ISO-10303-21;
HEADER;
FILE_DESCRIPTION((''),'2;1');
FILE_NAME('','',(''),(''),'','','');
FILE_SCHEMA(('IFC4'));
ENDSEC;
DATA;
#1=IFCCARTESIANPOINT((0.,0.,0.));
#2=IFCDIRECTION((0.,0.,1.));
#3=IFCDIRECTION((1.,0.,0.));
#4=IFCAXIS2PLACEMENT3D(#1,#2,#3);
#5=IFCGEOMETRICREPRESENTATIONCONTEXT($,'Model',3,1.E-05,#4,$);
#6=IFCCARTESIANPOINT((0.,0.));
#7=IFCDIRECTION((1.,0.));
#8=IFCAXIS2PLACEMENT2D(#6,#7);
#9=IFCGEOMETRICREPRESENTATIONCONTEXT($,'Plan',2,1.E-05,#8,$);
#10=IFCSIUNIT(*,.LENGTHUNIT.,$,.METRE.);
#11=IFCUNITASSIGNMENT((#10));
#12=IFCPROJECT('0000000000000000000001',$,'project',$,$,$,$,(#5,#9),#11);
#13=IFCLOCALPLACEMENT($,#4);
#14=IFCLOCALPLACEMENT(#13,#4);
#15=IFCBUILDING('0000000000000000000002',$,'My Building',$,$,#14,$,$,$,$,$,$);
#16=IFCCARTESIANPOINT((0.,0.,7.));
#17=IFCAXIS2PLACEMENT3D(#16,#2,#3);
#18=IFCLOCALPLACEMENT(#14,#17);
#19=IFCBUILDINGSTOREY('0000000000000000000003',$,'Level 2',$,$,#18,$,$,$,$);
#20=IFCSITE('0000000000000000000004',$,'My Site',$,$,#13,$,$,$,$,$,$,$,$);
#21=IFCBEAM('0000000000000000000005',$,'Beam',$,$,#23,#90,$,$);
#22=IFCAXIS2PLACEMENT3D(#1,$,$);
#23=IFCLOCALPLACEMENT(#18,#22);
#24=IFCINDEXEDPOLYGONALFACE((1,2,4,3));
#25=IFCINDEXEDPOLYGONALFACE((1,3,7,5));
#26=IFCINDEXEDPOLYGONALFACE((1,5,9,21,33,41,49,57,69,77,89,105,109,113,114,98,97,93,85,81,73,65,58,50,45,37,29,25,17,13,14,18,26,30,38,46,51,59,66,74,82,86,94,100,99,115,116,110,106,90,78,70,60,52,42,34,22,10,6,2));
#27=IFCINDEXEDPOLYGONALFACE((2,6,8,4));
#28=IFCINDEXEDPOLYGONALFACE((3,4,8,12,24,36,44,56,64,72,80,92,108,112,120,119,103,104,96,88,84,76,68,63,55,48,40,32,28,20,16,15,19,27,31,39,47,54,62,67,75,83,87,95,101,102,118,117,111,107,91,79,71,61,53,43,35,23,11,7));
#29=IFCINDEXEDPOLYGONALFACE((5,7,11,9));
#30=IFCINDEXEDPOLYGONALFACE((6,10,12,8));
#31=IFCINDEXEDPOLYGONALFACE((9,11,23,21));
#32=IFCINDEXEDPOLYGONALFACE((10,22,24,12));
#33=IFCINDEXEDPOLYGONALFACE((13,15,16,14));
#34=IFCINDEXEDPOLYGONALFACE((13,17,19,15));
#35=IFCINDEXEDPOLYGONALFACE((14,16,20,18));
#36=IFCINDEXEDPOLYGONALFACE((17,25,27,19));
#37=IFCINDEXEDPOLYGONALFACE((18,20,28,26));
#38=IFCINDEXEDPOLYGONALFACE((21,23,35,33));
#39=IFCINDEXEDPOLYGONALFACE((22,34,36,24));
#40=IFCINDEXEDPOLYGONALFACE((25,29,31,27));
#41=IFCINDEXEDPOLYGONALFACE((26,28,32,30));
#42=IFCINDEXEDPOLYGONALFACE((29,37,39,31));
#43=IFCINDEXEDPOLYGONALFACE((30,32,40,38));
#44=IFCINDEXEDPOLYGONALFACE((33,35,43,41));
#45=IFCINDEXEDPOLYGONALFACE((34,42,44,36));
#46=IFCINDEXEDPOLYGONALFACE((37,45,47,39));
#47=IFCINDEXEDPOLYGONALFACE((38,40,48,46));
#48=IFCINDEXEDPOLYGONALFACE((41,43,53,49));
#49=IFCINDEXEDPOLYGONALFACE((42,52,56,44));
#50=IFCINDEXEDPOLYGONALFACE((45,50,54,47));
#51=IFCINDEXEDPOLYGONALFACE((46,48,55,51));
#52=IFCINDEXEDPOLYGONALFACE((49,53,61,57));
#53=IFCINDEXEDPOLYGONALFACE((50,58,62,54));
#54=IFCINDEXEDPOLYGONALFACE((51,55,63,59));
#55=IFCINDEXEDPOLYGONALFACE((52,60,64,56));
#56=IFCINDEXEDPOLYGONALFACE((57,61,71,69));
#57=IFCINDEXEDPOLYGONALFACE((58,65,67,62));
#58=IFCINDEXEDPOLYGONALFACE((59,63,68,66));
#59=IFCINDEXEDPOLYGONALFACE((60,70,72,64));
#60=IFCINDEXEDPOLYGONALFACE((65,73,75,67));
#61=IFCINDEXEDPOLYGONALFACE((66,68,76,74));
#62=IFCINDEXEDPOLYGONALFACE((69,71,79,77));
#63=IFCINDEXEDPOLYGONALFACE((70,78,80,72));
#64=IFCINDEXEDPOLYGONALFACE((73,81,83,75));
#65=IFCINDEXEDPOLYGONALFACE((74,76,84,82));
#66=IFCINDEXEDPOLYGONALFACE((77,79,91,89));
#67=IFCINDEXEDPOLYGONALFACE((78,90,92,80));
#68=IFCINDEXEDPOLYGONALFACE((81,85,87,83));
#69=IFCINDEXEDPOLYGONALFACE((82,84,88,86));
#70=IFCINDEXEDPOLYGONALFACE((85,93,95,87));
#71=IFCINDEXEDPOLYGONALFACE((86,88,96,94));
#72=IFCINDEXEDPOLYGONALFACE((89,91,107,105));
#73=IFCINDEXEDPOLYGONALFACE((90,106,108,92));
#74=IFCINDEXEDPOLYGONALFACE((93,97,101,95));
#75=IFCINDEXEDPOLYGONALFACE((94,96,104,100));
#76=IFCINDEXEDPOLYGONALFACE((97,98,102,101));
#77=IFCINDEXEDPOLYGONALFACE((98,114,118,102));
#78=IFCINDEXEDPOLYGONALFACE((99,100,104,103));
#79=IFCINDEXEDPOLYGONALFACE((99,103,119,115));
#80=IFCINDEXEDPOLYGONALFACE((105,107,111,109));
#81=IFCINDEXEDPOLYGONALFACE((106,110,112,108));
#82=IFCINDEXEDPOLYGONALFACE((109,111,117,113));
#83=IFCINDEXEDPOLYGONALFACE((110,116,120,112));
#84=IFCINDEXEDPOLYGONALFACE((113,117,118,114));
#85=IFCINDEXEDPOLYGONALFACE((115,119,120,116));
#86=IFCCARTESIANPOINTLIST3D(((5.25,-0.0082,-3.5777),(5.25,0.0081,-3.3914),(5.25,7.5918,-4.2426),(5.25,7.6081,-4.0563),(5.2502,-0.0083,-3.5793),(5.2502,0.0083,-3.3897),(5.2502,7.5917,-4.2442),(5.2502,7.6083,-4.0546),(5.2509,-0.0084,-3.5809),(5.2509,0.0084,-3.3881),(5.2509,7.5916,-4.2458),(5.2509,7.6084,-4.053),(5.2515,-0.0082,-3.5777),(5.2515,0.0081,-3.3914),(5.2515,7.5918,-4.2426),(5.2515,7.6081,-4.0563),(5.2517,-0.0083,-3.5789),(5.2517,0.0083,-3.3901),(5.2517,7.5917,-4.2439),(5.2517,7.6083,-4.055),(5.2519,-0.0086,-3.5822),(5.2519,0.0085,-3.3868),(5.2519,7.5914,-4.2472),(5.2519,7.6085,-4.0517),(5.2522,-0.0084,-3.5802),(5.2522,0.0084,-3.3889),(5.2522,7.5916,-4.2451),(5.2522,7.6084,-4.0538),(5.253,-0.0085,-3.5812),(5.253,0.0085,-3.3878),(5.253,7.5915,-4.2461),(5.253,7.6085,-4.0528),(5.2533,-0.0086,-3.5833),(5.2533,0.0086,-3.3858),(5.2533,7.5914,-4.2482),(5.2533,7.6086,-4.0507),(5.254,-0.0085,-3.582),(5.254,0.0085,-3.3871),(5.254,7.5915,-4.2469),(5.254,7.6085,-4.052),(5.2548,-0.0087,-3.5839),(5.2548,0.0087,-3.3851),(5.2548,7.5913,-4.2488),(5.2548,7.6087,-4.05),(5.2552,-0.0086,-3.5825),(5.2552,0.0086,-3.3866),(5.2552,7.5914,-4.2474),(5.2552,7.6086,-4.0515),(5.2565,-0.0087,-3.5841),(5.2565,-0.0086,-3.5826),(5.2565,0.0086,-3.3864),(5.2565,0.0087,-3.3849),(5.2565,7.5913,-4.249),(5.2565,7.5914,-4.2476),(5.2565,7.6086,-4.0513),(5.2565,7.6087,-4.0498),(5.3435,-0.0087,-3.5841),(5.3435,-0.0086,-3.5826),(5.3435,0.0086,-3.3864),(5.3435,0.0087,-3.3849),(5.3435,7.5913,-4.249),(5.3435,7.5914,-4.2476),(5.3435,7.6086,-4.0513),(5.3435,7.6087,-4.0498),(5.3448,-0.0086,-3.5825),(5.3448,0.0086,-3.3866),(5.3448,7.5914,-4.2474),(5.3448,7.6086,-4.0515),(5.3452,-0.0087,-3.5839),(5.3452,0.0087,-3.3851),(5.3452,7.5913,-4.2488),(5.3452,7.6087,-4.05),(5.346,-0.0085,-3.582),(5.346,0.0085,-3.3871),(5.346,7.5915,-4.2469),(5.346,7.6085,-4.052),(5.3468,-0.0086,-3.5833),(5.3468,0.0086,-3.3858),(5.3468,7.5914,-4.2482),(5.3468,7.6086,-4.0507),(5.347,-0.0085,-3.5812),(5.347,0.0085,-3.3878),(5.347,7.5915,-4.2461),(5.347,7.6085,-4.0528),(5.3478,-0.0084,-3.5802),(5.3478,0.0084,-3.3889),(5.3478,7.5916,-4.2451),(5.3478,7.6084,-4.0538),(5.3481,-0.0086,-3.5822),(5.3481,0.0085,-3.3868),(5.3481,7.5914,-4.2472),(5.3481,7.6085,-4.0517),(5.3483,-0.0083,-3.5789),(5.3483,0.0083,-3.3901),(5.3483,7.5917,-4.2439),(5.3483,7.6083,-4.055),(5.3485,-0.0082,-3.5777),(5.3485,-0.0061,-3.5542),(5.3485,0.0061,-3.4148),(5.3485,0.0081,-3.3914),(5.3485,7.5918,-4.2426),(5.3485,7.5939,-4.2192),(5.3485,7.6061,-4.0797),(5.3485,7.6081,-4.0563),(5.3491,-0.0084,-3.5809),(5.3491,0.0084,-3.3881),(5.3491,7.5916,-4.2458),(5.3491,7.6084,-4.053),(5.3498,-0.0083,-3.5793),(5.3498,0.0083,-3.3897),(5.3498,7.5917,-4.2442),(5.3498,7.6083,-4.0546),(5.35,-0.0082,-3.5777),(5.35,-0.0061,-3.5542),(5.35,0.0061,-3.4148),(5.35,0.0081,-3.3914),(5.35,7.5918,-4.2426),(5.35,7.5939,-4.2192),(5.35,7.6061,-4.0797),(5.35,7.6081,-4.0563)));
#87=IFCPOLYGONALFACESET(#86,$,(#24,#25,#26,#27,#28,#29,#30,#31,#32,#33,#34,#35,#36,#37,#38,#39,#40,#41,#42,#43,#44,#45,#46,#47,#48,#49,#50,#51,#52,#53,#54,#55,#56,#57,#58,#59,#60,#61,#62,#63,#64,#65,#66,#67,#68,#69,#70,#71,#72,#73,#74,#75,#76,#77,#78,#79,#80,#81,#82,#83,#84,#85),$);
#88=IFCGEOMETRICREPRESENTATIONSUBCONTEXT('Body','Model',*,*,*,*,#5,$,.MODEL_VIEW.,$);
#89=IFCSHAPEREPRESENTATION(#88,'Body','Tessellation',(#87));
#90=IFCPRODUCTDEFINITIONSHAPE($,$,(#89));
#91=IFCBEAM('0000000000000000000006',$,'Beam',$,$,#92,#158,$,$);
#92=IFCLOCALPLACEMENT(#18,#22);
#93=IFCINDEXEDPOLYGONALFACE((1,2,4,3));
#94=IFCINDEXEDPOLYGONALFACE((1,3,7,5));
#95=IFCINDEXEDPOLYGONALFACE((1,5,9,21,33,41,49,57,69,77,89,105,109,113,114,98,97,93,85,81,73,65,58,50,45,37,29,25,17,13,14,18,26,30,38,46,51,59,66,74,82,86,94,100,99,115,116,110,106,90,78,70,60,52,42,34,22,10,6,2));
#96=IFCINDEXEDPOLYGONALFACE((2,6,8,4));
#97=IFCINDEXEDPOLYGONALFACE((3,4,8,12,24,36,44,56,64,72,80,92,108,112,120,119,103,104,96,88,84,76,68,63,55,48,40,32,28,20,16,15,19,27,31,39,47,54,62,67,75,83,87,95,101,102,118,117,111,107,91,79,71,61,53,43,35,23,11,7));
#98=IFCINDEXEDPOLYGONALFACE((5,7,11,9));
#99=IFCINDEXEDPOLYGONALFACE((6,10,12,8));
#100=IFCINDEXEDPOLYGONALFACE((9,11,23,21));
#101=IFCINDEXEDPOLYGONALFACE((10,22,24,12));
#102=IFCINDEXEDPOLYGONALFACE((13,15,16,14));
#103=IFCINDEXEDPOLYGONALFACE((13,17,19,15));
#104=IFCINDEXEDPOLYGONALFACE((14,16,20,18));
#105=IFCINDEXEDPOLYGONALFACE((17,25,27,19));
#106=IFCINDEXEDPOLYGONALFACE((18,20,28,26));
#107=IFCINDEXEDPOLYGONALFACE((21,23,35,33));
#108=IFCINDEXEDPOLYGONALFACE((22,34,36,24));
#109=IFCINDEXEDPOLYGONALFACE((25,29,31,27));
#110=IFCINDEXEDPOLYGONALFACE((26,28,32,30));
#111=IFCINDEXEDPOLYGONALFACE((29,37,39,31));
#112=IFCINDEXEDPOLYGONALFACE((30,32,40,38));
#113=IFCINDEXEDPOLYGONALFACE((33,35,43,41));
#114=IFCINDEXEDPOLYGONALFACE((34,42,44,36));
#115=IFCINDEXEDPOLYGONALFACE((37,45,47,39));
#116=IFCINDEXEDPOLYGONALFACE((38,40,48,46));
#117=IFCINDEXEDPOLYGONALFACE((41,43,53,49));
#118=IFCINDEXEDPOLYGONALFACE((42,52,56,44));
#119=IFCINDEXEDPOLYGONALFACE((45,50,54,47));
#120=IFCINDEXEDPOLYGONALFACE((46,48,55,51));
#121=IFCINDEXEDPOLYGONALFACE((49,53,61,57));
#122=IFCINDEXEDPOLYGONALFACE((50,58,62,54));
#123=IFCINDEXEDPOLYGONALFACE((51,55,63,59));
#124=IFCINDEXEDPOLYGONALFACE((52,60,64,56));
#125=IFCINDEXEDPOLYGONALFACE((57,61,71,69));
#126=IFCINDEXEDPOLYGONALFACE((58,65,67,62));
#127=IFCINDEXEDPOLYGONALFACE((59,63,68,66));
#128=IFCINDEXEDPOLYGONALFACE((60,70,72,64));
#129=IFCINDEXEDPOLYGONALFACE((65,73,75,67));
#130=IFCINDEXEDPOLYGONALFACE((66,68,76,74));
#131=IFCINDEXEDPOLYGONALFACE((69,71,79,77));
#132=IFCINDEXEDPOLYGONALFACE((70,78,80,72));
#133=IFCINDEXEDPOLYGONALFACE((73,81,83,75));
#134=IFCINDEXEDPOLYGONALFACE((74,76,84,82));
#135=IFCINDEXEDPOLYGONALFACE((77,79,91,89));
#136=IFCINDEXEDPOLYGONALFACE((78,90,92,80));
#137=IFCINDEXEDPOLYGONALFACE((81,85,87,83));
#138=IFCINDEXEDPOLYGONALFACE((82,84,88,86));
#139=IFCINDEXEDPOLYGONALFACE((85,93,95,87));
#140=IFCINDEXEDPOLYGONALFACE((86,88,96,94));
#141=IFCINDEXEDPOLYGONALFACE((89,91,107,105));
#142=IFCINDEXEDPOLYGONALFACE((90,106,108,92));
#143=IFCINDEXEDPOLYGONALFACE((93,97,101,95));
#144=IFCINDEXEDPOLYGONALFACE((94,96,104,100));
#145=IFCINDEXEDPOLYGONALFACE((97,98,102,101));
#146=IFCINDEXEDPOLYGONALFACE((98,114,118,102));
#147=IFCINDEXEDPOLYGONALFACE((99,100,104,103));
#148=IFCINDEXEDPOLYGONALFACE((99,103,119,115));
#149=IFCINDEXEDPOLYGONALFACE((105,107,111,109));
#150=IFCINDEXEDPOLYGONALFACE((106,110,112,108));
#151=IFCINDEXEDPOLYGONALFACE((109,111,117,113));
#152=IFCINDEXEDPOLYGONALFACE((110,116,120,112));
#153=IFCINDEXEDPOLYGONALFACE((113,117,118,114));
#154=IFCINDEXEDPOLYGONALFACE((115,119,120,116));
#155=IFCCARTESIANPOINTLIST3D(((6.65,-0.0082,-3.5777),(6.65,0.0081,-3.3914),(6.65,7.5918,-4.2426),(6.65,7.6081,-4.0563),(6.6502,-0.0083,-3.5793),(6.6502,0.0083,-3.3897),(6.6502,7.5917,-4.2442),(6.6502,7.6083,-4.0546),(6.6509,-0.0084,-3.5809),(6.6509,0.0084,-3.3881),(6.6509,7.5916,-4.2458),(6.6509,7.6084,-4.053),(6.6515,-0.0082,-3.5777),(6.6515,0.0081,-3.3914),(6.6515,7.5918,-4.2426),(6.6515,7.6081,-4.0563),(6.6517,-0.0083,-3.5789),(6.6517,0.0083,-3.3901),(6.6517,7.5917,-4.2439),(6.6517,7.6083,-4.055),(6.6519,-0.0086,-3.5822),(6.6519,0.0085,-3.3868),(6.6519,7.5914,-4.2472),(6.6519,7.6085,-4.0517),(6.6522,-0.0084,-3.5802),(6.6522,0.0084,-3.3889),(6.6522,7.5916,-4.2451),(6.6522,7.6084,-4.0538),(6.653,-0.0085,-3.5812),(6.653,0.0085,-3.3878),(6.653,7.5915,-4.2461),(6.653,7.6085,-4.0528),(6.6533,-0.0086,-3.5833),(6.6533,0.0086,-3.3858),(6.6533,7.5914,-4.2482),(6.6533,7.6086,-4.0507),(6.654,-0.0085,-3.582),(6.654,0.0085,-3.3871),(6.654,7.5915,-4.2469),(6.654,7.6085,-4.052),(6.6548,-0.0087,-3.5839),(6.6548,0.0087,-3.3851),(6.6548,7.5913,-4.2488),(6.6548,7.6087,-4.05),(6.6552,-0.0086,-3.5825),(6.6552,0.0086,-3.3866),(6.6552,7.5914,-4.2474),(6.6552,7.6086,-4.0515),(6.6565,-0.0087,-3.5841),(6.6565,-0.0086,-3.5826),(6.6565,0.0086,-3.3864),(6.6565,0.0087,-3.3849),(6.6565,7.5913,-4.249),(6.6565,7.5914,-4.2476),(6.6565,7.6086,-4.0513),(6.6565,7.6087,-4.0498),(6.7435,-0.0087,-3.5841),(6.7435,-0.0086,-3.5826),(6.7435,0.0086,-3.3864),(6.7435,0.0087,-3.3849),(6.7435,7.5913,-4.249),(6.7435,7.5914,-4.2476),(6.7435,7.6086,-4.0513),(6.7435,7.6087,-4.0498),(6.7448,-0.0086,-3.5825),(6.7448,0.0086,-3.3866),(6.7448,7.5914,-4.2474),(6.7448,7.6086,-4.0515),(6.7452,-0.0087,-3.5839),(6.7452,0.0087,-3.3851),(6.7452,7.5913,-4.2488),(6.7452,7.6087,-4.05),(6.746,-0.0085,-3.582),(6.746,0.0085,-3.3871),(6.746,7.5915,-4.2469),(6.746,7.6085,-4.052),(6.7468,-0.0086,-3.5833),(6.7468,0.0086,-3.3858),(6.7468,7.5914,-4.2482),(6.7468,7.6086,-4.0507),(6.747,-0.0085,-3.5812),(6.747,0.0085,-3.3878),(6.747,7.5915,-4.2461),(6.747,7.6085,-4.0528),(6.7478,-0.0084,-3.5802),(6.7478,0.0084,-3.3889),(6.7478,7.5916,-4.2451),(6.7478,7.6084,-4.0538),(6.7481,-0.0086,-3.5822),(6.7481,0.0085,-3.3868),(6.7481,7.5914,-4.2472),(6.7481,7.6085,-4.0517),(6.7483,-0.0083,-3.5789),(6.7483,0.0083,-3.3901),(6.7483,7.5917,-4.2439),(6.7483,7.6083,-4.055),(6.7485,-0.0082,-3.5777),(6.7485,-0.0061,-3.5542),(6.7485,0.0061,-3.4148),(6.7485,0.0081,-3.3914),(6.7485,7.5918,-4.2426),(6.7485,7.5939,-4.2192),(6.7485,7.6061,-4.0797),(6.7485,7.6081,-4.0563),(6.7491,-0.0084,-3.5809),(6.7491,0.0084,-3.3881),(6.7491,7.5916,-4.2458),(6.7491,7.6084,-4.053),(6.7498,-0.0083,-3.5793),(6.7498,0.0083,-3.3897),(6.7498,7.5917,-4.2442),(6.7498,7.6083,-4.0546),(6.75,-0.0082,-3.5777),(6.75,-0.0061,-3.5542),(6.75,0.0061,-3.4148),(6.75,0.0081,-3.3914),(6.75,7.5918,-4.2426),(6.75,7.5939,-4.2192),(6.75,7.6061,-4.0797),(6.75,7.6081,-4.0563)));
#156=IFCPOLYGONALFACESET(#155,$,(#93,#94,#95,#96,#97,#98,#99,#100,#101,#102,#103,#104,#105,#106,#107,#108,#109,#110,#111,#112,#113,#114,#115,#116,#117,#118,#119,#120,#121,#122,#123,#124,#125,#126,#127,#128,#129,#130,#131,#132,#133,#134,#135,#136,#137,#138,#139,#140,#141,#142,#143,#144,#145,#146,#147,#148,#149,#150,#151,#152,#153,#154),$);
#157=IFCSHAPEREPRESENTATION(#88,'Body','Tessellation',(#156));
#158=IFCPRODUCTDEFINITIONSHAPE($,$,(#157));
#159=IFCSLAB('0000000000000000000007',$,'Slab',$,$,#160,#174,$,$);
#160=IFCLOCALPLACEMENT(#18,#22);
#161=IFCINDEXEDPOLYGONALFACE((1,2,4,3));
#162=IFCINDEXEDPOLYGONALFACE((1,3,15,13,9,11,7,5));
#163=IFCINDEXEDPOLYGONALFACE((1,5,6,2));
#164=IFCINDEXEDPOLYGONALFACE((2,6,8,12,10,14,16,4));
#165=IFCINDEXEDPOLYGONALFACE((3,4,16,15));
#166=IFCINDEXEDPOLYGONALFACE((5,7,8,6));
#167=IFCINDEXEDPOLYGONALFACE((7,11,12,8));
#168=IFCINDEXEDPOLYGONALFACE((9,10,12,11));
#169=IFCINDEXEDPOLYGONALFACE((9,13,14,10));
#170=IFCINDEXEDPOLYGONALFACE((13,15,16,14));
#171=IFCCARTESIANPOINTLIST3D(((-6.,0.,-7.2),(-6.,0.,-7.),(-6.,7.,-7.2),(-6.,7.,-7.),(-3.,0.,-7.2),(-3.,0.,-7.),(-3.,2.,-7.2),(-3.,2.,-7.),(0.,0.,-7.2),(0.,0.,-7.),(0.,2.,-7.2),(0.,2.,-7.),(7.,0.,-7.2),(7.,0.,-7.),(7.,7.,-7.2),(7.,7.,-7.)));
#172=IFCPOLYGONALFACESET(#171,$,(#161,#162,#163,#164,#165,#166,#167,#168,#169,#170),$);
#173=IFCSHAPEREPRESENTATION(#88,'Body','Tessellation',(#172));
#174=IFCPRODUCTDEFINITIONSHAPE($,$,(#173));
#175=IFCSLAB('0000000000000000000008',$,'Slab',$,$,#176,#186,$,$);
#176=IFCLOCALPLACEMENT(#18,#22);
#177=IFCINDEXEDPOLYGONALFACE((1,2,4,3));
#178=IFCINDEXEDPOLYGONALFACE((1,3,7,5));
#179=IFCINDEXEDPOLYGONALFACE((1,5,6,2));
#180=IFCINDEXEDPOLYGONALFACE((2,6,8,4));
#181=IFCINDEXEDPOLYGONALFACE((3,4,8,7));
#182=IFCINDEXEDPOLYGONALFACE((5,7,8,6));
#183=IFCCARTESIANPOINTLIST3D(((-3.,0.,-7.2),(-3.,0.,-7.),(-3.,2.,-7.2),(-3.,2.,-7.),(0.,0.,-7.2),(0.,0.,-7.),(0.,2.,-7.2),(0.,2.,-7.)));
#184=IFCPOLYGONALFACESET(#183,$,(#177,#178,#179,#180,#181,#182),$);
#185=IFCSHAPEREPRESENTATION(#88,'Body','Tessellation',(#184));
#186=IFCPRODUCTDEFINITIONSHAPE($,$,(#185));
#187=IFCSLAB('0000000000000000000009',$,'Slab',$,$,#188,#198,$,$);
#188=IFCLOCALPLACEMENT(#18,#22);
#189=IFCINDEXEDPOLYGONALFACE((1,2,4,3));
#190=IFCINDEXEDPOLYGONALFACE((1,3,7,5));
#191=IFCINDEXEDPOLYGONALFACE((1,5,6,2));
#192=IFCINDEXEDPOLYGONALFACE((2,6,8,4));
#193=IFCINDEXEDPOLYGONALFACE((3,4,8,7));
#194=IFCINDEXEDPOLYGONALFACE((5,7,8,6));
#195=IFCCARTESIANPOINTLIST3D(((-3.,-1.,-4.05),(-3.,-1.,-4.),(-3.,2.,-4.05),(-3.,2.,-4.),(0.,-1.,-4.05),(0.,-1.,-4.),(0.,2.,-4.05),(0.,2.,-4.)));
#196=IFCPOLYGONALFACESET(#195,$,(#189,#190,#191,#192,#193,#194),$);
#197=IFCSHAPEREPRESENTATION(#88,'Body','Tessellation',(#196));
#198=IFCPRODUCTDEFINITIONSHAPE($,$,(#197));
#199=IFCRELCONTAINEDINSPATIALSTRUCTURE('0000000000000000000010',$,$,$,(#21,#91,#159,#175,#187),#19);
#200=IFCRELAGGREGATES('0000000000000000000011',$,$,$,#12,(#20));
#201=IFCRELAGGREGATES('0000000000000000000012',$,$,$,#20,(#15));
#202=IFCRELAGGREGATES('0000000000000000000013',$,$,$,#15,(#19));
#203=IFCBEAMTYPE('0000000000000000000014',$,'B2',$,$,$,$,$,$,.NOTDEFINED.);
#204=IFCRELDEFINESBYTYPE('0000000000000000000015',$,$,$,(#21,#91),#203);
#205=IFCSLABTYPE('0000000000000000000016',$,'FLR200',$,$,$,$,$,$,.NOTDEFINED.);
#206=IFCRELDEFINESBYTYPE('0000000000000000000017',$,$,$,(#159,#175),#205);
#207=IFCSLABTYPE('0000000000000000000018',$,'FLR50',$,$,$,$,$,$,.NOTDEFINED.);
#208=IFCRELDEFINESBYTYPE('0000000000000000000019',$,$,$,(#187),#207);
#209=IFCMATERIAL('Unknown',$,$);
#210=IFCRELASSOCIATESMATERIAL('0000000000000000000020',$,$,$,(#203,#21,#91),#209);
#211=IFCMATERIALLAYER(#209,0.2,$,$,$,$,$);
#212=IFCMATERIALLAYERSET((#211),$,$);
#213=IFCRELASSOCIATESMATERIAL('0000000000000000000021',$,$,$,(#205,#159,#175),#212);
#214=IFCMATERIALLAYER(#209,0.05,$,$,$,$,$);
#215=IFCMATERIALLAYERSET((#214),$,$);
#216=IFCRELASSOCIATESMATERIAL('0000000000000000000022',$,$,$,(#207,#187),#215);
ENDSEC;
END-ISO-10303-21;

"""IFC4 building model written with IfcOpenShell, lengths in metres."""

from ifc_helpers import new_model, si_unit, frame, origin_with_axes, origin_2d_with_axis, place, context, subcontext, project, spatial, indexed_curve, c_section, outline, extrude, material, layer, layer_set, layer_usage, material_profile, profile_set, profile_usage, type_object, element, save


model = new_model("IFC4")

# Units and contexts
model_context = context("Model", 3, precision=1e-05, world=origin_with_axes())
plan_context = context("Plan", 2, precision=1e-05, world=origin_2d_with_axis())
body_context = subcontext(model_context, "Body", "Model", "MODEL_VIEW")
ifc_project = project(units=[si_unit("LENGTHUNIT", "METRE")], contexts=[model_context, plan_context])

# Site, building, storey
site_placement = place(None, origin_with_axes())
site = spatial("IfcSite", under=ifc_project, at=site_placement, Name="My Site")
building_placement = place(site_placement, origin_with_axes())
building = spatial("IfcBuilding", under=site, at=building_placement, Name="My Building")
storey_placement = place(building_placement, frame((0.0, 0.0, 7.0), z_axis=(0.0, 0.0, 1.0), x_axis=(1.0, 0.0, 0.0)))
storey = spatial("IfcBuildingStorey", under=building, at=storey_placement, Name="Level 2")

# Shared definitions
ifc_material = material(Name="Unknown")

# Beams
ifc_material_profile_1 = material_profile(ifc_material, c_section(Depth=0.2, Width=0.1, WallThickness=0.0015, Girth=0.03, InternalFilletRadius=0.005))
ifc_profile_set_1 = profile_set([ifc_material_profile_1])
beam_type_1 = type_object("IfcBeamType", Name="B2", PredefinedType="NOTDEFINED", material=ifc_profile_set_1)
ifc_profile_usage_1 = profile_usage(ifc_profile_set_1, cardinal=5)
beam_1_placement = place(storey_placement, frame((5.3, 7.6, -4.1494), z_axis=(0.0, -0.996195, 0.087156), x_axis=(1.0, 0.0, 0.0)))
element("IfcBeam", 1, at=beam_1_placement, inside=storey, type_object=beam_type_1, material=ifc_profile_usage_1, Name="Beam", context=body_context, shape_type="SweptSolid", body=[
    extrude(c_section(Depth=0.2, Width=0.1, WallThickness=0.0015, Girth=0.03, InternalFilletRadius=0.005), origin_with_axes(), (0.0, 0.0, 1.0), 7.629),
])
ifc_profile_usage_2 = profile_usage(ifc_profile_set_1, cardinal=5)
beam_2_placement = place(storey_placement, frame((6.7, 7.6, -4.1494), z_axis=(0.0, -0.996195, 0.087156), x_axis=(1.0, 0.0, 0.0)))
element("IfcBeam", 2, at=beam_2_placement, inside=storey, type_object=beam_type_1, material=ifc_profile_usage_2, Name="Beam", context=body_context, shape_type="SweptSolid", body=[
    extrude(c_section(Depth=0.2, Width=0.1, WallThickness=0.0015, Girth=0.03, InternalFilletRadius=0.005), origin_with_axes(), (0.0, 0.0, 1.0), 7.629),
])

# Slabs
ifc_layer_1 = layer(ifc_material, 0.2)
ifc_layer_set_1 = layer_set([ifc_layer_1])
ifc_layer_usage_1 = layer_usage(ifc_layer_set_1, "AXIS3", "POSITIVE", -0.2)
slab_type_1 = type_object("IfcSlabType", Name="FLR200", PredefinedType="NOTDEFINED", material=ifc_layer_set_1)
slab_1_placement = place(storey_placement, frame((-6.0, 7.0, -7.0), z_axis=(0.0, 0.0, 1.0), x_axis=(1.0, 0.0, 0.0)))
element("IfcSlab", 3, at=slab_1_placement, inside=storey, type_object=slab_type_1, material=ifc_layer_usage_1, Name="Slab", context=body_context, shape_type="SweptSolid", body=[
    extrude(outline(indexed_curve([(0.0, 0.0), (0.0, -7.0), (3.0, -7.0), (3.0, -5.0), (6.0, -5.0), (6.0, -7.0), (13.0, -7.0), (13.0, 0.0), (0.0, 0.0)])), frame((0.0, 0.0, -0.2), z_axis=(0.0, 0.0, 1.0), x_axis=(1.0, 0.0, 0.0)), (0.0, 0.0, 1.0), 0.2),
])
ifc_layer_usage_2 = layer_usage(ifc_layer_set_1, "AXIS3", "POSITIVE", -0.2)
slab_2_placement = place(storey_placement, frame((-3.0, 0.0, -7.0), z_axis=(0.0, 0.0, 1.0), x_axis=(1.0, 0.0, 0.0)))
element("IfcSlab", 4, at=slab_2_placement, inside=storey, type_object=slab_type_1, material=ifc_layer_usage_2, Name="Slab", context=body_context, shape_type="SweptSolid", body=[
    extrude(outline(indexed_curve([(0.0, 0.0), (0.0, 2.0), (3.0, 2.0), (3.0, 0.0), (0.0, 0.0)])), frame((0.0, 0.0, -0.2), z_axis=(0.0, 0.0, 1.0), x_axis=(1.0, 0.0, 0.0)), (0.0, 0.0, 1.0), 0.2),
])
ifc_layer_2 = layer(ifc_material, 0.05)
ifc_layer_set_2 = layer_set([ifc_layer_2])
slab_type_2 = type_object("IfcSlabType", Name="FLR50", PredefinedType="NOTDEFINED", material=ifc_layer_set_2)
ifc_layer_usage_3 = layer_usage(ifc_layer_set_2, "AXIS3", "POSITIVE", -0.05)
slab_3_placement = place(storey_placement, frame((-3.0, 0.0, -4.0), z_axis=(0.0, 0.0, 1.0), x_axis=(1.0, 0.0, 0.0)))
element("IfcSlab", 5, at=slab_3_placement, inside=storey, type_object=slab_type_2, material=ifc_layer_usage_3, Name="Slab", context=body_context, shape_type="SweptSolid", body=[
    extrude(outline(indexed_curve([(3.0, -1.0), (3.0, 2.0), (0.0, 2.0), (0.0, -1.0), (3.0, -1.0)])), frame((0.0, 0.0, -0.05), z_axis=(0.0, 0.0, 1.0), x_axis=(1.0, 0.0, 0.0)), (0.0, 0.0, 1.0), 0.05),
])

save(model, "model.ifc")
